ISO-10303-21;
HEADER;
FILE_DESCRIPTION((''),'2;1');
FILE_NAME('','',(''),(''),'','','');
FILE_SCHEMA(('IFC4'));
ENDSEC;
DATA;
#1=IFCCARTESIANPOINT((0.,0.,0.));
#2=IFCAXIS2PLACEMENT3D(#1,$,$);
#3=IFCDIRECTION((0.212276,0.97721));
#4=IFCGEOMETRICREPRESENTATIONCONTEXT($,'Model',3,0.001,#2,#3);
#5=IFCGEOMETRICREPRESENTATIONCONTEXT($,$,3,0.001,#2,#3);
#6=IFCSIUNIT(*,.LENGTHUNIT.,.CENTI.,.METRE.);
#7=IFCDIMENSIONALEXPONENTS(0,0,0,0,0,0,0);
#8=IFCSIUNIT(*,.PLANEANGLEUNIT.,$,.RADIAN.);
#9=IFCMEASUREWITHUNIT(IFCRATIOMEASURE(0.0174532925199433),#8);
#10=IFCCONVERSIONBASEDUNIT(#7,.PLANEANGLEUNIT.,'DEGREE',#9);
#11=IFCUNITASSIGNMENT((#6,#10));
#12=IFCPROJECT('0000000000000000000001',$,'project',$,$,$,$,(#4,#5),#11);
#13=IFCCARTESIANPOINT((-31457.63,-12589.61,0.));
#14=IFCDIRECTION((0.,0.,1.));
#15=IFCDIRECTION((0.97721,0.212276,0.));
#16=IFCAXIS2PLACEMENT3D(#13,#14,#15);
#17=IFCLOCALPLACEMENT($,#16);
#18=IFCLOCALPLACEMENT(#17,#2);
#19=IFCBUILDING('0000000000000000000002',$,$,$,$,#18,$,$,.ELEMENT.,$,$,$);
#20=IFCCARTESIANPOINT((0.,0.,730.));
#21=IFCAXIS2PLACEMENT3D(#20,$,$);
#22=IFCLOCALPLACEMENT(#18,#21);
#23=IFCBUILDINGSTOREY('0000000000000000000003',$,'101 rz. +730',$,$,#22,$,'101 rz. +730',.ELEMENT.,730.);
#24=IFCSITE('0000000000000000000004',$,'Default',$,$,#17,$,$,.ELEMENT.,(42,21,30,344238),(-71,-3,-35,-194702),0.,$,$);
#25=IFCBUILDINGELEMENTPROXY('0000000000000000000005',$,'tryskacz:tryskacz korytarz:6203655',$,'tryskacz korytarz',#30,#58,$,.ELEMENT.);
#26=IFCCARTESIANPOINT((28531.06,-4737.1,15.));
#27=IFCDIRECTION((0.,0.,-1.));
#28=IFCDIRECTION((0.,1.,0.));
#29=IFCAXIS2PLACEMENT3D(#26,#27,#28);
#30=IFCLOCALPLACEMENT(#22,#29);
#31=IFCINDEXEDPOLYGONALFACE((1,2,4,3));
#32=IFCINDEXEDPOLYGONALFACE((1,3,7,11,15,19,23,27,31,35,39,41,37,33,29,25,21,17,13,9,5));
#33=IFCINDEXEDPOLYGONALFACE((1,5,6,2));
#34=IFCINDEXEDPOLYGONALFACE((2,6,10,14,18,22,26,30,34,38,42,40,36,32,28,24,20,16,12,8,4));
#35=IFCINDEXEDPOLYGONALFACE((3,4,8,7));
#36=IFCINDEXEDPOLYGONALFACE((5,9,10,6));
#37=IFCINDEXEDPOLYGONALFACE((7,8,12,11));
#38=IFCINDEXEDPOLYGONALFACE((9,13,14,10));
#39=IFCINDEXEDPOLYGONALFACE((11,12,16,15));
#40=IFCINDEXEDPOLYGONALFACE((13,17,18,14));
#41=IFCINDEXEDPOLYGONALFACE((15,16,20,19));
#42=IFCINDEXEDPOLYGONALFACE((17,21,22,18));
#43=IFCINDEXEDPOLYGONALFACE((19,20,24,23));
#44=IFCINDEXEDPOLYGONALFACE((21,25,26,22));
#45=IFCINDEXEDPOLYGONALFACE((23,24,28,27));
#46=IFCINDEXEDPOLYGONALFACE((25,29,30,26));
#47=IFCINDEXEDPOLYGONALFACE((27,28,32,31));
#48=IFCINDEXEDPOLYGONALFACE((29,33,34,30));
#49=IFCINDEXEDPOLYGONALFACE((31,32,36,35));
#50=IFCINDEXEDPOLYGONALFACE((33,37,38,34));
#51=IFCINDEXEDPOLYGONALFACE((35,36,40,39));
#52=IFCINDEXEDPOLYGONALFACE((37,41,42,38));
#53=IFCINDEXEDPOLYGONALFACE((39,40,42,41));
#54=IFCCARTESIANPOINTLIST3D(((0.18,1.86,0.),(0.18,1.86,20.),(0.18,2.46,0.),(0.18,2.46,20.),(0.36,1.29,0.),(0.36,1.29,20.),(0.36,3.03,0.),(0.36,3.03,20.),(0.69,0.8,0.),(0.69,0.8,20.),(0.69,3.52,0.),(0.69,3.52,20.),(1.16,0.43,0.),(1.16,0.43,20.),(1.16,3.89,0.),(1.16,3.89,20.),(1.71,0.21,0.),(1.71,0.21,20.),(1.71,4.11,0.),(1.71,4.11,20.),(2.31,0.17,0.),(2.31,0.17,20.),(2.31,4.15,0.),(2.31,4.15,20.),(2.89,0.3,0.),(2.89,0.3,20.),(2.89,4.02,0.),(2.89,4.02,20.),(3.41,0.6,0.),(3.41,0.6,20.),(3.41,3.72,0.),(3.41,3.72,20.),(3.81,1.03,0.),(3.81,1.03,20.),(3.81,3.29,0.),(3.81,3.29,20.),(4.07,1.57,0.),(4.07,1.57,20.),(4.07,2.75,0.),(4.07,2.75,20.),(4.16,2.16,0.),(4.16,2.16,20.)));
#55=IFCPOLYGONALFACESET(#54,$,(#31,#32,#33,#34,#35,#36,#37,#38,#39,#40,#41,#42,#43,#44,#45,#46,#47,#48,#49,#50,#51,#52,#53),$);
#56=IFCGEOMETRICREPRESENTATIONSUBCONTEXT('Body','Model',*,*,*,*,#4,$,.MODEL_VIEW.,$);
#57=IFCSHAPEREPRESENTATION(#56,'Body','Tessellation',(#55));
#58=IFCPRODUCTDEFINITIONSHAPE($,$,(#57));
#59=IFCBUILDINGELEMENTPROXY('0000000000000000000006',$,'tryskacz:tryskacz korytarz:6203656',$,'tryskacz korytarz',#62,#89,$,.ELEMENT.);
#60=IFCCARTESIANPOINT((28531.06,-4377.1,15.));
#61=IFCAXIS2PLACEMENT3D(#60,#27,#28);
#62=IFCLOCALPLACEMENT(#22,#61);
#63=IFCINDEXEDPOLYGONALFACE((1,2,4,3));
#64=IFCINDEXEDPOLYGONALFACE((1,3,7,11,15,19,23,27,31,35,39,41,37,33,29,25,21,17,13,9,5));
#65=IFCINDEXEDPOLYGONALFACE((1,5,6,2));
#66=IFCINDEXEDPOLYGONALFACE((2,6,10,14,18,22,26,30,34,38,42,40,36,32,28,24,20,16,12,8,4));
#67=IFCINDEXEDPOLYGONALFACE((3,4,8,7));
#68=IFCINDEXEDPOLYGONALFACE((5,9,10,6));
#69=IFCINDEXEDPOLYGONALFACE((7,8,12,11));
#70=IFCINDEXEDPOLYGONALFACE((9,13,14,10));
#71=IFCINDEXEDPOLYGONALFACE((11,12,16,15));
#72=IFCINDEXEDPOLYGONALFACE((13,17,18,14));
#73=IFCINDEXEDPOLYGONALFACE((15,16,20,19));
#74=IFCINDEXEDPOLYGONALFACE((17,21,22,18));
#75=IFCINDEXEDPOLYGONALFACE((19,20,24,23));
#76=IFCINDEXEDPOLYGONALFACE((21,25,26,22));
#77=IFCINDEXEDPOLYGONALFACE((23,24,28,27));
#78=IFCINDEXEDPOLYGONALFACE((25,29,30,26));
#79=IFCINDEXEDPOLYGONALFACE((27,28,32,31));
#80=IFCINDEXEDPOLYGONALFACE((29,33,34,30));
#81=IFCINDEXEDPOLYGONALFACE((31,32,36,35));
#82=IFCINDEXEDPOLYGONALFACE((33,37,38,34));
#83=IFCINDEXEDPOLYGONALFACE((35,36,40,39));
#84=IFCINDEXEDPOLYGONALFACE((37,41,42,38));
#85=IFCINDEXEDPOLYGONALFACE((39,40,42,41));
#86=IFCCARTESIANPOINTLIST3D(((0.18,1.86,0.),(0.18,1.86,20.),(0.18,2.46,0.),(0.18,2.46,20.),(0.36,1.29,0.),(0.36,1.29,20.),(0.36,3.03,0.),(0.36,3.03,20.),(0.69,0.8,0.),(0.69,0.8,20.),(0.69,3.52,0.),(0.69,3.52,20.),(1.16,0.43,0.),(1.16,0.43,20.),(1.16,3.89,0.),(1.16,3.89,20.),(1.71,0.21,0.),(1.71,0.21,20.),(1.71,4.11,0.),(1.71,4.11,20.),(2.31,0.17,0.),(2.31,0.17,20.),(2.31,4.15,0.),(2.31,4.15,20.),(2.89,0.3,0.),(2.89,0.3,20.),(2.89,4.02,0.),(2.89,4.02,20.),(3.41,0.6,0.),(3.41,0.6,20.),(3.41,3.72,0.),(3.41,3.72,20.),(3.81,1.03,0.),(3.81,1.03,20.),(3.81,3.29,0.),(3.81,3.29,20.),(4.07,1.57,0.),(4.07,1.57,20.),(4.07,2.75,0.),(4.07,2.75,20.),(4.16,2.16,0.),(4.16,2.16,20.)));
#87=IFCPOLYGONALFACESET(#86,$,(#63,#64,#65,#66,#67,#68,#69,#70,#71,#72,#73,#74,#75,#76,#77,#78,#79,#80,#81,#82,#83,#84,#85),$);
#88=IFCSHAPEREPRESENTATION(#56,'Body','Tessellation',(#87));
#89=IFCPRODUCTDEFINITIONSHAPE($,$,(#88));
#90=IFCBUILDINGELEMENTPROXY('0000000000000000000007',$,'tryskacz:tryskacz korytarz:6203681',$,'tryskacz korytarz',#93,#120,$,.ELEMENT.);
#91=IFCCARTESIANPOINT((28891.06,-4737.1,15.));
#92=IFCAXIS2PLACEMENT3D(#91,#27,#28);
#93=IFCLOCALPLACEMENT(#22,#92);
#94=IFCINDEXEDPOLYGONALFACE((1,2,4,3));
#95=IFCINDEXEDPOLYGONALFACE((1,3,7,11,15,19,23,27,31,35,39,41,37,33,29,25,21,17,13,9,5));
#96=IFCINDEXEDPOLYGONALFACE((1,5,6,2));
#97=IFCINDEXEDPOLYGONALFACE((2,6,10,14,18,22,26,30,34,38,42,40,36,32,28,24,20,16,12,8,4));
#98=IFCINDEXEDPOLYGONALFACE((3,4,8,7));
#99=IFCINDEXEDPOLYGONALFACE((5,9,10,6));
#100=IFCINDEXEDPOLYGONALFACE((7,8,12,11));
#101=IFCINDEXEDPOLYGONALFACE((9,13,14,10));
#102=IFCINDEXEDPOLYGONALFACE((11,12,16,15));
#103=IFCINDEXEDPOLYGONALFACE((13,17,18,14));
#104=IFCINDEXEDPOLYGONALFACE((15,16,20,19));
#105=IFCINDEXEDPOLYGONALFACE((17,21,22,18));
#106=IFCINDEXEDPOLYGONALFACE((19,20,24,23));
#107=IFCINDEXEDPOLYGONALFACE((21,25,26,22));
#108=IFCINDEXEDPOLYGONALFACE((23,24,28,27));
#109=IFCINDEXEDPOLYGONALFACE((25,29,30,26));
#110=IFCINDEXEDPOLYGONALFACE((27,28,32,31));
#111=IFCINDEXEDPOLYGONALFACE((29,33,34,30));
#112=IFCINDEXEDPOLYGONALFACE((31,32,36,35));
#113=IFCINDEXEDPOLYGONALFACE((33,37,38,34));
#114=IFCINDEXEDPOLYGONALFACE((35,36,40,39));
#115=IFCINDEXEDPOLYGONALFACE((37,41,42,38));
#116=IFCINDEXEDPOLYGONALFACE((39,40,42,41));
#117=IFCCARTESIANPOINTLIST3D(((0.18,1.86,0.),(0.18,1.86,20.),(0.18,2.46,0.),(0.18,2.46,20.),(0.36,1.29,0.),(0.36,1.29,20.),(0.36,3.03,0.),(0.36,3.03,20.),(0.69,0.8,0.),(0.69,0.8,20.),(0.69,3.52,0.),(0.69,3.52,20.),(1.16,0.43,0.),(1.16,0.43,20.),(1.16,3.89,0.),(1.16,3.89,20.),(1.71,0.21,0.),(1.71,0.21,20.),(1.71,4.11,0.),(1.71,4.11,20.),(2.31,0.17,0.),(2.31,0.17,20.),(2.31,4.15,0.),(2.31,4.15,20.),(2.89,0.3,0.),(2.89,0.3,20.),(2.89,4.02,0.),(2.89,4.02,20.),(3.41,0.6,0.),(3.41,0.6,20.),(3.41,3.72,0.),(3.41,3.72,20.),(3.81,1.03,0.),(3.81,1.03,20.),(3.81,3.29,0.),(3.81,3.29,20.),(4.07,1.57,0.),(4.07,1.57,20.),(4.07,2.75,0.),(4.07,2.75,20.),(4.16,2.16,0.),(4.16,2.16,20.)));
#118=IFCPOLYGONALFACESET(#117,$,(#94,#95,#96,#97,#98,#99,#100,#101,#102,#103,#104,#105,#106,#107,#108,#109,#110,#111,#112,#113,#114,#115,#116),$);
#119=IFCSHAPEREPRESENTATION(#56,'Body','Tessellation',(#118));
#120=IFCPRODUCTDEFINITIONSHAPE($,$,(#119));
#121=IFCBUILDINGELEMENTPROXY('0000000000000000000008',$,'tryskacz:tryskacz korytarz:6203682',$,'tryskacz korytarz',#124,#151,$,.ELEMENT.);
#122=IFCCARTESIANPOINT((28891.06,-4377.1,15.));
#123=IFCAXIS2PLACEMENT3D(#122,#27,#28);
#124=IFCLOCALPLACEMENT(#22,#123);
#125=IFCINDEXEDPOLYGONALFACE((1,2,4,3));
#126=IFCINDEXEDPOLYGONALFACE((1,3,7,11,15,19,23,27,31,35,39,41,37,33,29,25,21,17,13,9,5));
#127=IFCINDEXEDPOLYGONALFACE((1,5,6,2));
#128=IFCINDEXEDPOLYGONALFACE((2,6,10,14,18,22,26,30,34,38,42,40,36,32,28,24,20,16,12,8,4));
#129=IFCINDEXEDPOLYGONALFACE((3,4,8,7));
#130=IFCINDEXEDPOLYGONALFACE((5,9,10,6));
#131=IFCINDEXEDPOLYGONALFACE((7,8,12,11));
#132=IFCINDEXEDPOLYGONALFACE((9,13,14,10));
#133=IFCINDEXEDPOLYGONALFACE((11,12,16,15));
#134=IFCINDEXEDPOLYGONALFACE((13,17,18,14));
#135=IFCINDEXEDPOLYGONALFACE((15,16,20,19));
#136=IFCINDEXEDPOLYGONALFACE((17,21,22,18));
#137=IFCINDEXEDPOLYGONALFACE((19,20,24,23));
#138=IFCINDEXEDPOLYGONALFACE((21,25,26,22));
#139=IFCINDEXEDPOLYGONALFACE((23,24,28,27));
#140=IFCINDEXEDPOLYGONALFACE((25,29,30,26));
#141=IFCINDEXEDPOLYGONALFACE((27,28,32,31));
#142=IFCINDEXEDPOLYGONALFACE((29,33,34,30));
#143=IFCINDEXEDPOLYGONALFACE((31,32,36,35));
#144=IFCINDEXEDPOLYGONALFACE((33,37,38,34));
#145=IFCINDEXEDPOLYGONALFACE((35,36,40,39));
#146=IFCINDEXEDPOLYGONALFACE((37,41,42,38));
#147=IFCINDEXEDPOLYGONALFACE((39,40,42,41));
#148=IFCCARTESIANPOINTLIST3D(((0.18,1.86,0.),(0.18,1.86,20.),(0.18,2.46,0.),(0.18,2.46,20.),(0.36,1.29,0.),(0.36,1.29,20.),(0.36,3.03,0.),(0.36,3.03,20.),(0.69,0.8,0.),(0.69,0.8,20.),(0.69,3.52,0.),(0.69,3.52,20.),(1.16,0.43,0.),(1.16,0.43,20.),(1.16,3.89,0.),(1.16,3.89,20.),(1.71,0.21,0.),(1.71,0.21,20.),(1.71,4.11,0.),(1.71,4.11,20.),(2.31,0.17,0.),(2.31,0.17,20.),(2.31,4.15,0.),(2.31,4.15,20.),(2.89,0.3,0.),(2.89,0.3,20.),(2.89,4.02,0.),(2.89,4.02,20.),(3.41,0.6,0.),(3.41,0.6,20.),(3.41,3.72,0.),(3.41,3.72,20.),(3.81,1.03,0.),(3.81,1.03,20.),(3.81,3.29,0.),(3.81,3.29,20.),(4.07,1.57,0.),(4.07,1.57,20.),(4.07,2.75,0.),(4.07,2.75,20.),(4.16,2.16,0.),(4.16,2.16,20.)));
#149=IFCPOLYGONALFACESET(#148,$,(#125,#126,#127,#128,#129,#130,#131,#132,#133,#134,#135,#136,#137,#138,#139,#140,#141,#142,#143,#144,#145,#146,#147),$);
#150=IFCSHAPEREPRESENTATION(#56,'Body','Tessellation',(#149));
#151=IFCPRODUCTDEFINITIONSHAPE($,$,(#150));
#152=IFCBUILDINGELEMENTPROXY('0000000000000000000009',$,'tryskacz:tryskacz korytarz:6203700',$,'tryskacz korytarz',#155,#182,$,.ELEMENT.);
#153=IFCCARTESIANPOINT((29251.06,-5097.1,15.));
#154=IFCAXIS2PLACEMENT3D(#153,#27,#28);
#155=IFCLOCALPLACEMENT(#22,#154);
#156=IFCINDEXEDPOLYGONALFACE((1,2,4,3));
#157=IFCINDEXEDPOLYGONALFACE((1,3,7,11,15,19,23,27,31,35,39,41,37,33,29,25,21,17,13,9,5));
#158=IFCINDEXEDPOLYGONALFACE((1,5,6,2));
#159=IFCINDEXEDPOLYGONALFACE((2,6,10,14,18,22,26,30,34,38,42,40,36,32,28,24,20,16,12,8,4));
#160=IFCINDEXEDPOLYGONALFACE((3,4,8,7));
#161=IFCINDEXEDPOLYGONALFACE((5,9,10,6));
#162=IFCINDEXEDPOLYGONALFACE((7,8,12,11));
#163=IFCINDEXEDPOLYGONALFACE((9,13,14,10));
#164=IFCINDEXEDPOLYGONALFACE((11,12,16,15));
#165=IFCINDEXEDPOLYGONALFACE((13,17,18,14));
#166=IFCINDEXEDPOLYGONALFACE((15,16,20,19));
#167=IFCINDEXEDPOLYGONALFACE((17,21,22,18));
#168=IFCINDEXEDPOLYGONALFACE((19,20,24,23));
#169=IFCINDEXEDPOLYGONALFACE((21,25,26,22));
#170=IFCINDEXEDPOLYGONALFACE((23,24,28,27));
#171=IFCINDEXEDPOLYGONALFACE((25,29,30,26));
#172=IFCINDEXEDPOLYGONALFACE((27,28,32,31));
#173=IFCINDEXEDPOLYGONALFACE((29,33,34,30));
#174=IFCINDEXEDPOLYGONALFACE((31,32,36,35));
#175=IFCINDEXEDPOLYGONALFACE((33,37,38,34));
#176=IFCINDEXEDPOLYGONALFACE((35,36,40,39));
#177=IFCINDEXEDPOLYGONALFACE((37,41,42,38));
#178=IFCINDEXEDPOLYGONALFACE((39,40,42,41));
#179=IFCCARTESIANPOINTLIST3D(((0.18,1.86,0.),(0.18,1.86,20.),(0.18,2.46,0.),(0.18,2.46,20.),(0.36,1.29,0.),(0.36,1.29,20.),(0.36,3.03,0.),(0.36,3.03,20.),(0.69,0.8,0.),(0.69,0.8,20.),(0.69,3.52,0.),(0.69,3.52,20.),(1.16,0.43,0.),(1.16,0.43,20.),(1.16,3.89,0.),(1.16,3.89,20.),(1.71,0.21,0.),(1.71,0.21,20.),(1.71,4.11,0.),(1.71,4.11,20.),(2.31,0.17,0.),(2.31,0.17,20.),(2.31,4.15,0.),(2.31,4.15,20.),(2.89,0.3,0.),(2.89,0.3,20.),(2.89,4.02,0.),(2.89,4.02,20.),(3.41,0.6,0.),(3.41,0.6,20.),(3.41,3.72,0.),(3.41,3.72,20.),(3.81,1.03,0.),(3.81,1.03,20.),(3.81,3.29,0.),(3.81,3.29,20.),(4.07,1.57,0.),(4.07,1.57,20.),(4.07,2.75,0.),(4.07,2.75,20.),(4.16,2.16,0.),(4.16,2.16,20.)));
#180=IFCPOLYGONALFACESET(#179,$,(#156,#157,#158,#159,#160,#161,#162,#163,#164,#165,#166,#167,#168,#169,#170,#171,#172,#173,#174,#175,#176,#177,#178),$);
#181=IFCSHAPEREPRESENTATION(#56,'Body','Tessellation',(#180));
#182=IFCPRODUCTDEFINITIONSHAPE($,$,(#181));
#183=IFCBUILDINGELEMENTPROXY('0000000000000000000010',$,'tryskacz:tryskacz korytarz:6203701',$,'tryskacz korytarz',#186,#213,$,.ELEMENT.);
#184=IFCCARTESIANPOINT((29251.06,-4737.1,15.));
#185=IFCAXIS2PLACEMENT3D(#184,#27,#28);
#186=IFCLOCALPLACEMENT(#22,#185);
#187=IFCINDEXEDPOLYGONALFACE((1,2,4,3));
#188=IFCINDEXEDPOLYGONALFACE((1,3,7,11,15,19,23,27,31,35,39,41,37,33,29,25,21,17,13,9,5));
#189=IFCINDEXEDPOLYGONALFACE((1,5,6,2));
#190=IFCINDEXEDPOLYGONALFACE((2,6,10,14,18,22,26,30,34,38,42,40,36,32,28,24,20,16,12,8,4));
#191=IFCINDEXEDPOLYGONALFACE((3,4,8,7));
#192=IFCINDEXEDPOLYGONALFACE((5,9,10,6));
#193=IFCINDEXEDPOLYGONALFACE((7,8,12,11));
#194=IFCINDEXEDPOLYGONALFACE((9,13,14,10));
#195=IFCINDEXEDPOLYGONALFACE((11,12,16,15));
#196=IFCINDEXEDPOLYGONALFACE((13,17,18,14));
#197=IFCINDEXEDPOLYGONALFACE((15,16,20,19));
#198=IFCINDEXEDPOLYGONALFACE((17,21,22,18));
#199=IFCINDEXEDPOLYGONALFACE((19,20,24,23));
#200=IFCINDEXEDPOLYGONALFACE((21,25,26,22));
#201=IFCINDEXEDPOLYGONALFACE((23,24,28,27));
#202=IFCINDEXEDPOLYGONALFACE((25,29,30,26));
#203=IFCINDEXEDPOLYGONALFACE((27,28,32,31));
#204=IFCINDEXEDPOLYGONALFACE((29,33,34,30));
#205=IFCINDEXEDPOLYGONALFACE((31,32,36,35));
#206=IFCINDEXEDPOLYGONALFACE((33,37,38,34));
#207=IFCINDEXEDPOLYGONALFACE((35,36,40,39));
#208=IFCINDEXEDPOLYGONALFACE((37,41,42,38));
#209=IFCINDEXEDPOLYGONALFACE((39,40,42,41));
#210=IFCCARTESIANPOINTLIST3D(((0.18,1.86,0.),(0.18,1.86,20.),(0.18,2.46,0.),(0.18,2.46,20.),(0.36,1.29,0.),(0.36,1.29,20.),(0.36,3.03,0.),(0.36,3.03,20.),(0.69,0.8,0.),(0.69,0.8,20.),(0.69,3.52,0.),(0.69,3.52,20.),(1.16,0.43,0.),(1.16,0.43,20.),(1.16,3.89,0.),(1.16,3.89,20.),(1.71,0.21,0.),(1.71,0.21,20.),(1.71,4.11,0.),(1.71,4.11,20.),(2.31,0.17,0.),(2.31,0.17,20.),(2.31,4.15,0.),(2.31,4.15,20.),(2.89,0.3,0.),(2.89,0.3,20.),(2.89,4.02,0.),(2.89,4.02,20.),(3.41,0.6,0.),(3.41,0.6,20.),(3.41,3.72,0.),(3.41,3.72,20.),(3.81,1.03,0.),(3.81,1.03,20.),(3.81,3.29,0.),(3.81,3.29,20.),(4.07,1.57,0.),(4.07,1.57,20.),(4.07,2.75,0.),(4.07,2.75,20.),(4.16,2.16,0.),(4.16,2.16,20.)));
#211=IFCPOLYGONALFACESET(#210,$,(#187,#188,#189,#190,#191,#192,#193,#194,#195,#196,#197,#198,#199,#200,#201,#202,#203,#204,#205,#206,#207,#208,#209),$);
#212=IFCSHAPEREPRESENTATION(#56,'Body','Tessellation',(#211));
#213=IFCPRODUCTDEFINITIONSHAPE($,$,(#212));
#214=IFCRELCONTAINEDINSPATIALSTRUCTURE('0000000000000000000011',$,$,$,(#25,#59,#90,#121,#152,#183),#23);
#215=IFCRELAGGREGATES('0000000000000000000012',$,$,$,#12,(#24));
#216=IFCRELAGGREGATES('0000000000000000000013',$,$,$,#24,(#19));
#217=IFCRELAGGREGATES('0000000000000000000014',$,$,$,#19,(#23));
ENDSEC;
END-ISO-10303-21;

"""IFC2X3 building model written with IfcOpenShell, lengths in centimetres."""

from ifc_helpers import new_model, entity, si_unit, converted_unit, direction, frame, frame_2d, origin, place, context, subcontext, project, spatial, circle, extrude, source, transform, mapped, element, save


model = new_model("IFC2X3")

# Units and contexts
model_context = context("Model", 3, precision=0.001, world=origin(), true_north=direction((0.212276, 0.97721)))
context_of_model = context(None, 3, precision=0.001, world=origin(), true_north=direction((0.212276, 0.97721)))
body_context = subcontext(model_context, "Body", "Model", "MODEL_VIEW")
ifc_project = project(units=[si_unit("LENGTHUNIT", "METRE", prefix="CENTI"), converted_unit("PLANEANGLEUNIT", "DEGREE", entity("IfcRatioMeasure", 0.0174532925199433), si_unit("PLANEANGLEUNIT", "RADIAN"), dimensions=[0, 0, 0, 0, 0, 0, 0])], contexts=[model_context, context_of_model])

# Site, building, storey
site_placement = place(None, frame((-31457.63, -12589.61, 0.0), z_axis=(0.0, 0.0, 1.0), x_axis=(0.97721, 0.212276, 0.0)))
site = spatial("IfcSite", under=ifc_project, at=site_placement, Name="Default", CompositionType="ELEMENT", RefLatitude=(42, 21, 30, 344238), RefLongitude=(-71, -3, -35, -194702), RefElevation=0.0)
building_placement = place(site_placement, origin())
building = spatial("IfcBuilding", under=site, at=building_placement, CompositionType="ELEMENT")
storey_placement = place(building_placement, frame((0.0, 0.0, 730.0)))
storey = spatial("IfcBuildingStorey", under=building, at=storey_placement, Name="101 rz. +730", LongName="101 rz. +730", CompositionType="ELEMENT", Elevation=730.0)

# Building element proxies
shared_shape_1 = source(origin(), body_context, "Body", "SweptSolid", [
    extrude(circle(Radius=2.0, at=frame_2d((0.0, 0.0), x_axis=(1.0, 0.0))), frame((2.16, 2.16, 0.0)), (0.0, 0.0, 1.0), 20.0),
])
for number, where, z_axis, x_axis, name in (
    (1, (28531.06, -4737.1, 15.0), (0.0, 0.0, -1.0), (0.0, 1.0, 0.0), "tryskacz:tryskacz korytarz:6203655"),
    (2, (28531.06, -4377.1, 15.0), (0.0, 0.0, -1.0), (0.0, 1.0, 0.0), "tryskacz:tryskacz korytarz:6203656"),
    (3, (28891.06, -4737.1, 15.0), (0.0, 0.0, -1.0), (0.0, 1.0, 0.0), "tryskacz:tryskacz korytarz:6203681"),
    (4, (28891.06, -4377.1, 15.0), (0.0, 0.0, -1.0), (0.0, 1.0, 0.0), "tryskacz:tryskacz korytarz:6203682"),
    (5, (29251.06, -5097.1, 15.0), (0.0, 0.0, -1.0), (0.0, 1.0, 0.0), "tryskacz:tryskacz korytarz:6203700"),
    (6, (29251.06, -4737.1, 15.0), (0.0, 0.0, -1.0), (0.0, 1.0, 0.0), "tryskacz:tryskacz korytarz:6203701"),
):
    element("IfcBuildingElementProxy", number, at=place(storey_placement, frame(where, z_axis=z_axis, x_axis=x_axis)), inside=storey, Name=name, ObjectType="tryskacz korytarz", CompositionType="ELEMENT", context=body_context, shape_type="MappedRepresentation", body=[
        mapped(shared_shape_1, transform((0.0, 0.0, 0.0), scale=1.0)),
    ])

save(model, "model.ifc")
